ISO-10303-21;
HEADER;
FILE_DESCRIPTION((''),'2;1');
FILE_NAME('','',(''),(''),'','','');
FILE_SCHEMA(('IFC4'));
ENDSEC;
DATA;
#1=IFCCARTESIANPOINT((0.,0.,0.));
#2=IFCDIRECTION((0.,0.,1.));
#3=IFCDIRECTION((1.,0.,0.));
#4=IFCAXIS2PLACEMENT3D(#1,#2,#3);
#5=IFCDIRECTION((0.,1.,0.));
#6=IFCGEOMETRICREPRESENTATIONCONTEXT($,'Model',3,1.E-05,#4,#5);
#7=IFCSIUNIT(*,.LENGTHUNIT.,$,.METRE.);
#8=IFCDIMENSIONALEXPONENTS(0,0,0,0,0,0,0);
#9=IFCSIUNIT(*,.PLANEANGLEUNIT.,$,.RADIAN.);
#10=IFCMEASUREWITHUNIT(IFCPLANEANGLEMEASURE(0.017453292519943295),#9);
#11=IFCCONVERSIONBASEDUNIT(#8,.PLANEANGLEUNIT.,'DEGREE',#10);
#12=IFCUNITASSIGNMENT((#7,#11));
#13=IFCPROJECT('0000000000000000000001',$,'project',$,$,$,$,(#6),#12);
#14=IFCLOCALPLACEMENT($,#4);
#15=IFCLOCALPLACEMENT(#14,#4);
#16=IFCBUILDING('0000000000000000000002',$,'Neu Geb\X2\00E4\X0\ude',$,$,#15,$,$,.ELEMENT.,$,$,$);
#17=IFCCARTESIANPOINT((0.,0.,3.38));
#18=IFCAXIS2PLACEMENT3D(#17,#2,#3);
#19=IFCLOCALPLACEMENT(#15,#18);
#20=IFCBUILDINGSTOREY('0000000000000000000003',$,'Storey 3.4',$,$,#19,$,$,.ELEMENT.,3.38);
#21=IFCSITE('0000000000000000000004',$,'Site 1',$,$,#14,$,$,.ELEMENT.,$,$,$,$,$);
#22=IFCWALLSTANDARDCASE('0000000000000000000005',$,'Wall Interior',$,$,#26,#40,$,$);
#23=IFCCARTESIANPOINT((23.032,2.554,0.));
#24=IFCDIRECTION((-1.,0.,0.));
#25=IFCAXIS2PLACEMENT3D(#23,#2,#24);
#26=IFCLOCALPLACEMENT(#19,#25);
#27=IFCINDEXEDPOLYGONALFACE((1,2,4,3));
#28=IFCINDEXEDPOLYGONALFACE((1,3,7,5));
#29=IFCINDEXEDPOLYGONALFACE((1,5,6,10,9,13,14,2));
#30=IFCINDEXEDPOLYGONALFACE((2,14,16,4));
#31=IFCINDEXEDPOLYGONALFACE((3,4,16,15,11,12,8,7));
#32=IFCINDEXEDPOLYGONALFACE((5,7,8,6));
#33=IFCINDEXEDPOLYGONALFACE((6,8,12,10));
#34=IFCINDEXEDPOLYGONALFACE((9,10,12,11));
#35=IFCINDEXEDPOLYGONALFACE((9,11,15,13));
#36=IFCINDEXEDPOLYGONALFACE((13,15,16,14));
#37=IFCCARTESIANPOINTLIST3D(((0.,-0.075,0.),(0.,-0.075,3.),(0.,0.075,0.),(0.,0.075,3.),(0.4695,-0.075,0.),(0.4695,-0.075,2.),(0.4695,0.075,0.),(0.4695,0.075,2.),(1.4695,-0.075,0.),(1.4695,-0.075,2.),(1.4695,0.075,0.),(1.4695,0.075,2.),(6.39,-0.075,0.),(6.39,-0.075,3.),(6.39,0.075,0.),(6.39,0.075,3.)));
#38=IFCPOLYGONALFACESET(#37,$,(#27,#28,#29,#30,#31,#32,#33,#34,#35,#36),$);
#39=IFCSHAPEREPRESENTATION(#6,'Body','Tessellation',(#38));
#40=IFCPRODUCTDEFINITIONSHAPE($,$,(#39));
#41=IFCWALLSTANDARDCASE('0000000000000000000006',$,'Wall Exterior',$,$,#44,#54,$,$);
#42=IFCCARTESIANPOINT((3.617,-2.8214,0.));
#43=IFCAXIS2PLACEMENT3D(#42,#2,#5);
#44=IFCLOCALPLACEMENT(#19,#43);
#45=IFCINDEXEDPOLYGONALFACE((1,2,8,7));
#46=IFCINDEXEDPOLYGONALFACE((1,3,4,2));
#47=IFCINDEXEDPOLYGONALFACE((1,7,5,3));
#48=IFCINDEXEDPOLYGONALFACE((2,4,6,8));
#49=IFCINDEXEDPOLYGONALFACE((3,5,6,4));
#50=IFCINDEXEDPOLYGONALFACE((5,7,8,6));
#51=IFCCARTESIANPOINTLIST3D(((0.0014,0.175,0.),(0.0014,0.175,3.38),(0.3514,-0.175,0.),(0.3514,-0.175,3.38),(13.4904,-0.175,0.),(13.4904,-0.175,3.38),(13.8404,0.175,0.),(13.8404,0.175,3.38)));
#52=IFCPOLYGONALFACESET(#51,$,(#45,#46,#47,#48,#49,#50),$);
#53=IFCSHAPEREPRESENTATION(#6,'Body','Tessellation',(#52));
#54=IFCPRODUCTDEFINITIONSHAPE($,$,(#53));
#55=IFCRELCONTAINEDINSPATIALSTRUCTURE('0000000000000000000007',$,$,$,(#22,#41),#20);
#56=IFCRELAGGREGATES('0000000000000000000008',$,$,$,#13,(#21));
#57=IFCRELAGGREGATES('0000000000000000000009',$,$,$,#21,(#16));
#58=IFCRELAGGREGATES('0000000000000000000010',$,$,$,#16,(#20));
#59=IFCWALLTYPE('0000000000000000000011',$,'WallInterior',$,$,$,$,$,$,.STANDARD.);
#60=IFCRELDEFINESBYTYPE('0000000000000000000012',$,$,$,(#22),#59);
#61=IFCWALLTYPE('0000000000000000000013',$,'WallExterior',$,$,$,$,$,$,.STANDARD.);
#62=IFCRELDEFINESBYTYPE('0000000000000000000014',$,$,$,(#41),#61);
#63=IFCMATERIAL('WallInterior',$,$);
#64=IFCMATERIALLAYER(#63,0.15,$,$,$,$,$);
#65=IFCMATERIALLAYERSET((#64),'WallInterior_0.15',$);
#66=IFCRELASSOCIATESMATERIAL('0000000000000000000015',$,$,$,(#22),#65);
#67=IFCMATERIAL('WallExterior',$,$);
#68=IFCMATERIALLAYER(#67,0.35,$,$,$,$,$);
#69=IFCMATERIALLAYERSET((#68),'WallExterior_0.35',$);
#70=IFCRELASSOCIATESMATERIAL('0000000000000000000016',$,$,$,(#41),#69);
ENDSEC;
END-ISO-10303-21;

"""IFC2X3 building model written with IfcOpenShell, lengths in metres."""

from ifc_helpers import new_model, entity, si_unit, converted_unit, direction, frame, origin_with_axes, place, context, project, spatial, polyline, outline, extrude, material, layer, layer_set, layer_usage, type_object, element, save


model = new_model("IFC2X3")

# Units and contexts
model_context = context("Model", 3, precision=1e-05, world=origin_with_axes(), true_north=direction((0.0, 1.0, 0.0)))
ifc_project = project(units=[si_unit("LENGTHUNIT", "METRE"), converted_unit("PLANEANGLEUNIT", "DEGREE", entity("IfcPlaneAngleMeasure", 0.017453292519943295), si_unit("PLANEANGLEUNIT", "RADIAN"), dimensions=[0, 0, 0, 0, 0, 0, 0])], contexts=[model_context])

# Site, building, storey
site_placement = place(None, origin_with_axes())
site = spatial("IfcSite", under=ifc_project, at=site_placement, Name="Site 1", CompositionType="ELEMENT")
building_placement = place(site_placement, origin_with_axes())
building = spatial("IfcBuilding", under=site, at=building_placement, Name="Neu Gebäude", CompositionType="ELEMENT")
storey_placement = place(building_placement, frame((0.0, 0.0, 3.38), z_axis=(0.0, 0.0, 1.0), x_axis=(1.0, 0.0, 0.0)))
storey = spatial("IfcBuildingStorey", under=building, at=storey_placement, Name="Storey 3.4", CompositionType="ELEMENT", Elevation=3.38)

# Shared definitions
ifc_material_1 = material(Name="WallInterior")
wall_type_1 = type_object("IfcWallType", Name="WallInterior", PredefinedType="STANDARD")

# Wall, opening
ifc_layer_1 = layer(ifc_material_1, 0.15)
ifc_layer_set_1 = layer_set([ifc_layer_1], Name="WallInterior_0.15")
ifc_layer_usage_1 = layer_usage(ifc_layer_set_1, "AXIS2", "POSITIVE", -0.075)
wall_1_placement = place(storey_placement, frame((23.032, 2.554, 0.0), z_axis=(0.0, 0.0, 1.0), x_axis=(-1.0, 0.0, 0.0)))
wall_1 = element("IfcWallStandardCase", 1, at=wall_1_placement, inside=storey, type_object=wall_type_1, material=ifc_layer_usage_1, Name="Wall Interior", context=model_context, shape_type="SweptSolid", body=[
    extrude(outline(polyline([(0.0, -0.075), (6.39, -0.075), (6.39, 0.075), (0.0, 0.075), (0.0, -0.075)])), origin_with_axes(), (0.0, 0.0, 1.0), 3.0),
])
opening_1_placement = place(wall_1_placement, frame((0.9695, 0.0, 0.0), z_axis=(0.0, 0.0, 1.0), x_axis=(1.0, 0.0, 0.0)))
element("IfcOpeningElement", 2, at=opening_1_placement, cuts=wall_1, context=model_context, shape_type="SweptSolid", body=[
    extrude(outline(polyline([(-0.5, 0.172), (0.5, 0.172), (0.5, -0.172), (-0.5, -0.172), (-0.5, 0.172)])), origin_with_axes(), (0.0, 0.0, 1.0), 2.0),
])

# Shared definitions
ifc_material_2 = material(Name="WallExterior")
ifc_layer_2 = layer(ifc_material_2, 0.35)
ifc_layer_set_2 = layer_set([ifc_layer_2], Name="WallExterior_0.35")
ifc_layer_usage_2 = layer_usage(ifc_layer_set_2, "AXIS2", "POSITIVE", -0.175)
wall_type_2 = type_object("IfcWallType", Name="WallExterior", PredefinedType="STANDARD")

# Wall
wall_2_placement = place(storey_placement, frame((3.617, -2.8214, 0.0), z_axis=(0.0, 0.0, 1.0), x_axis=(0.0, 1.0, 0.0)))
element("IfcWallStandardCase", 3, at=wall_2_placement, inside=storey, type_object=wall_type_2, material=ifc_layer_usage_2, Name="Wall Exterior", context=model_context, shape_type="SweptSolid", body=[
    extrude(outline(polyline([(0.3514, -0.175), (13.4904, -0.175), (13.8404, 0.175), (0.0014, 0.175), (0.3514, -0.175)])), origin_with_axes(), (0.0, 0.0, 1.0), 3.38),
])

save(model, "model.ifc")
